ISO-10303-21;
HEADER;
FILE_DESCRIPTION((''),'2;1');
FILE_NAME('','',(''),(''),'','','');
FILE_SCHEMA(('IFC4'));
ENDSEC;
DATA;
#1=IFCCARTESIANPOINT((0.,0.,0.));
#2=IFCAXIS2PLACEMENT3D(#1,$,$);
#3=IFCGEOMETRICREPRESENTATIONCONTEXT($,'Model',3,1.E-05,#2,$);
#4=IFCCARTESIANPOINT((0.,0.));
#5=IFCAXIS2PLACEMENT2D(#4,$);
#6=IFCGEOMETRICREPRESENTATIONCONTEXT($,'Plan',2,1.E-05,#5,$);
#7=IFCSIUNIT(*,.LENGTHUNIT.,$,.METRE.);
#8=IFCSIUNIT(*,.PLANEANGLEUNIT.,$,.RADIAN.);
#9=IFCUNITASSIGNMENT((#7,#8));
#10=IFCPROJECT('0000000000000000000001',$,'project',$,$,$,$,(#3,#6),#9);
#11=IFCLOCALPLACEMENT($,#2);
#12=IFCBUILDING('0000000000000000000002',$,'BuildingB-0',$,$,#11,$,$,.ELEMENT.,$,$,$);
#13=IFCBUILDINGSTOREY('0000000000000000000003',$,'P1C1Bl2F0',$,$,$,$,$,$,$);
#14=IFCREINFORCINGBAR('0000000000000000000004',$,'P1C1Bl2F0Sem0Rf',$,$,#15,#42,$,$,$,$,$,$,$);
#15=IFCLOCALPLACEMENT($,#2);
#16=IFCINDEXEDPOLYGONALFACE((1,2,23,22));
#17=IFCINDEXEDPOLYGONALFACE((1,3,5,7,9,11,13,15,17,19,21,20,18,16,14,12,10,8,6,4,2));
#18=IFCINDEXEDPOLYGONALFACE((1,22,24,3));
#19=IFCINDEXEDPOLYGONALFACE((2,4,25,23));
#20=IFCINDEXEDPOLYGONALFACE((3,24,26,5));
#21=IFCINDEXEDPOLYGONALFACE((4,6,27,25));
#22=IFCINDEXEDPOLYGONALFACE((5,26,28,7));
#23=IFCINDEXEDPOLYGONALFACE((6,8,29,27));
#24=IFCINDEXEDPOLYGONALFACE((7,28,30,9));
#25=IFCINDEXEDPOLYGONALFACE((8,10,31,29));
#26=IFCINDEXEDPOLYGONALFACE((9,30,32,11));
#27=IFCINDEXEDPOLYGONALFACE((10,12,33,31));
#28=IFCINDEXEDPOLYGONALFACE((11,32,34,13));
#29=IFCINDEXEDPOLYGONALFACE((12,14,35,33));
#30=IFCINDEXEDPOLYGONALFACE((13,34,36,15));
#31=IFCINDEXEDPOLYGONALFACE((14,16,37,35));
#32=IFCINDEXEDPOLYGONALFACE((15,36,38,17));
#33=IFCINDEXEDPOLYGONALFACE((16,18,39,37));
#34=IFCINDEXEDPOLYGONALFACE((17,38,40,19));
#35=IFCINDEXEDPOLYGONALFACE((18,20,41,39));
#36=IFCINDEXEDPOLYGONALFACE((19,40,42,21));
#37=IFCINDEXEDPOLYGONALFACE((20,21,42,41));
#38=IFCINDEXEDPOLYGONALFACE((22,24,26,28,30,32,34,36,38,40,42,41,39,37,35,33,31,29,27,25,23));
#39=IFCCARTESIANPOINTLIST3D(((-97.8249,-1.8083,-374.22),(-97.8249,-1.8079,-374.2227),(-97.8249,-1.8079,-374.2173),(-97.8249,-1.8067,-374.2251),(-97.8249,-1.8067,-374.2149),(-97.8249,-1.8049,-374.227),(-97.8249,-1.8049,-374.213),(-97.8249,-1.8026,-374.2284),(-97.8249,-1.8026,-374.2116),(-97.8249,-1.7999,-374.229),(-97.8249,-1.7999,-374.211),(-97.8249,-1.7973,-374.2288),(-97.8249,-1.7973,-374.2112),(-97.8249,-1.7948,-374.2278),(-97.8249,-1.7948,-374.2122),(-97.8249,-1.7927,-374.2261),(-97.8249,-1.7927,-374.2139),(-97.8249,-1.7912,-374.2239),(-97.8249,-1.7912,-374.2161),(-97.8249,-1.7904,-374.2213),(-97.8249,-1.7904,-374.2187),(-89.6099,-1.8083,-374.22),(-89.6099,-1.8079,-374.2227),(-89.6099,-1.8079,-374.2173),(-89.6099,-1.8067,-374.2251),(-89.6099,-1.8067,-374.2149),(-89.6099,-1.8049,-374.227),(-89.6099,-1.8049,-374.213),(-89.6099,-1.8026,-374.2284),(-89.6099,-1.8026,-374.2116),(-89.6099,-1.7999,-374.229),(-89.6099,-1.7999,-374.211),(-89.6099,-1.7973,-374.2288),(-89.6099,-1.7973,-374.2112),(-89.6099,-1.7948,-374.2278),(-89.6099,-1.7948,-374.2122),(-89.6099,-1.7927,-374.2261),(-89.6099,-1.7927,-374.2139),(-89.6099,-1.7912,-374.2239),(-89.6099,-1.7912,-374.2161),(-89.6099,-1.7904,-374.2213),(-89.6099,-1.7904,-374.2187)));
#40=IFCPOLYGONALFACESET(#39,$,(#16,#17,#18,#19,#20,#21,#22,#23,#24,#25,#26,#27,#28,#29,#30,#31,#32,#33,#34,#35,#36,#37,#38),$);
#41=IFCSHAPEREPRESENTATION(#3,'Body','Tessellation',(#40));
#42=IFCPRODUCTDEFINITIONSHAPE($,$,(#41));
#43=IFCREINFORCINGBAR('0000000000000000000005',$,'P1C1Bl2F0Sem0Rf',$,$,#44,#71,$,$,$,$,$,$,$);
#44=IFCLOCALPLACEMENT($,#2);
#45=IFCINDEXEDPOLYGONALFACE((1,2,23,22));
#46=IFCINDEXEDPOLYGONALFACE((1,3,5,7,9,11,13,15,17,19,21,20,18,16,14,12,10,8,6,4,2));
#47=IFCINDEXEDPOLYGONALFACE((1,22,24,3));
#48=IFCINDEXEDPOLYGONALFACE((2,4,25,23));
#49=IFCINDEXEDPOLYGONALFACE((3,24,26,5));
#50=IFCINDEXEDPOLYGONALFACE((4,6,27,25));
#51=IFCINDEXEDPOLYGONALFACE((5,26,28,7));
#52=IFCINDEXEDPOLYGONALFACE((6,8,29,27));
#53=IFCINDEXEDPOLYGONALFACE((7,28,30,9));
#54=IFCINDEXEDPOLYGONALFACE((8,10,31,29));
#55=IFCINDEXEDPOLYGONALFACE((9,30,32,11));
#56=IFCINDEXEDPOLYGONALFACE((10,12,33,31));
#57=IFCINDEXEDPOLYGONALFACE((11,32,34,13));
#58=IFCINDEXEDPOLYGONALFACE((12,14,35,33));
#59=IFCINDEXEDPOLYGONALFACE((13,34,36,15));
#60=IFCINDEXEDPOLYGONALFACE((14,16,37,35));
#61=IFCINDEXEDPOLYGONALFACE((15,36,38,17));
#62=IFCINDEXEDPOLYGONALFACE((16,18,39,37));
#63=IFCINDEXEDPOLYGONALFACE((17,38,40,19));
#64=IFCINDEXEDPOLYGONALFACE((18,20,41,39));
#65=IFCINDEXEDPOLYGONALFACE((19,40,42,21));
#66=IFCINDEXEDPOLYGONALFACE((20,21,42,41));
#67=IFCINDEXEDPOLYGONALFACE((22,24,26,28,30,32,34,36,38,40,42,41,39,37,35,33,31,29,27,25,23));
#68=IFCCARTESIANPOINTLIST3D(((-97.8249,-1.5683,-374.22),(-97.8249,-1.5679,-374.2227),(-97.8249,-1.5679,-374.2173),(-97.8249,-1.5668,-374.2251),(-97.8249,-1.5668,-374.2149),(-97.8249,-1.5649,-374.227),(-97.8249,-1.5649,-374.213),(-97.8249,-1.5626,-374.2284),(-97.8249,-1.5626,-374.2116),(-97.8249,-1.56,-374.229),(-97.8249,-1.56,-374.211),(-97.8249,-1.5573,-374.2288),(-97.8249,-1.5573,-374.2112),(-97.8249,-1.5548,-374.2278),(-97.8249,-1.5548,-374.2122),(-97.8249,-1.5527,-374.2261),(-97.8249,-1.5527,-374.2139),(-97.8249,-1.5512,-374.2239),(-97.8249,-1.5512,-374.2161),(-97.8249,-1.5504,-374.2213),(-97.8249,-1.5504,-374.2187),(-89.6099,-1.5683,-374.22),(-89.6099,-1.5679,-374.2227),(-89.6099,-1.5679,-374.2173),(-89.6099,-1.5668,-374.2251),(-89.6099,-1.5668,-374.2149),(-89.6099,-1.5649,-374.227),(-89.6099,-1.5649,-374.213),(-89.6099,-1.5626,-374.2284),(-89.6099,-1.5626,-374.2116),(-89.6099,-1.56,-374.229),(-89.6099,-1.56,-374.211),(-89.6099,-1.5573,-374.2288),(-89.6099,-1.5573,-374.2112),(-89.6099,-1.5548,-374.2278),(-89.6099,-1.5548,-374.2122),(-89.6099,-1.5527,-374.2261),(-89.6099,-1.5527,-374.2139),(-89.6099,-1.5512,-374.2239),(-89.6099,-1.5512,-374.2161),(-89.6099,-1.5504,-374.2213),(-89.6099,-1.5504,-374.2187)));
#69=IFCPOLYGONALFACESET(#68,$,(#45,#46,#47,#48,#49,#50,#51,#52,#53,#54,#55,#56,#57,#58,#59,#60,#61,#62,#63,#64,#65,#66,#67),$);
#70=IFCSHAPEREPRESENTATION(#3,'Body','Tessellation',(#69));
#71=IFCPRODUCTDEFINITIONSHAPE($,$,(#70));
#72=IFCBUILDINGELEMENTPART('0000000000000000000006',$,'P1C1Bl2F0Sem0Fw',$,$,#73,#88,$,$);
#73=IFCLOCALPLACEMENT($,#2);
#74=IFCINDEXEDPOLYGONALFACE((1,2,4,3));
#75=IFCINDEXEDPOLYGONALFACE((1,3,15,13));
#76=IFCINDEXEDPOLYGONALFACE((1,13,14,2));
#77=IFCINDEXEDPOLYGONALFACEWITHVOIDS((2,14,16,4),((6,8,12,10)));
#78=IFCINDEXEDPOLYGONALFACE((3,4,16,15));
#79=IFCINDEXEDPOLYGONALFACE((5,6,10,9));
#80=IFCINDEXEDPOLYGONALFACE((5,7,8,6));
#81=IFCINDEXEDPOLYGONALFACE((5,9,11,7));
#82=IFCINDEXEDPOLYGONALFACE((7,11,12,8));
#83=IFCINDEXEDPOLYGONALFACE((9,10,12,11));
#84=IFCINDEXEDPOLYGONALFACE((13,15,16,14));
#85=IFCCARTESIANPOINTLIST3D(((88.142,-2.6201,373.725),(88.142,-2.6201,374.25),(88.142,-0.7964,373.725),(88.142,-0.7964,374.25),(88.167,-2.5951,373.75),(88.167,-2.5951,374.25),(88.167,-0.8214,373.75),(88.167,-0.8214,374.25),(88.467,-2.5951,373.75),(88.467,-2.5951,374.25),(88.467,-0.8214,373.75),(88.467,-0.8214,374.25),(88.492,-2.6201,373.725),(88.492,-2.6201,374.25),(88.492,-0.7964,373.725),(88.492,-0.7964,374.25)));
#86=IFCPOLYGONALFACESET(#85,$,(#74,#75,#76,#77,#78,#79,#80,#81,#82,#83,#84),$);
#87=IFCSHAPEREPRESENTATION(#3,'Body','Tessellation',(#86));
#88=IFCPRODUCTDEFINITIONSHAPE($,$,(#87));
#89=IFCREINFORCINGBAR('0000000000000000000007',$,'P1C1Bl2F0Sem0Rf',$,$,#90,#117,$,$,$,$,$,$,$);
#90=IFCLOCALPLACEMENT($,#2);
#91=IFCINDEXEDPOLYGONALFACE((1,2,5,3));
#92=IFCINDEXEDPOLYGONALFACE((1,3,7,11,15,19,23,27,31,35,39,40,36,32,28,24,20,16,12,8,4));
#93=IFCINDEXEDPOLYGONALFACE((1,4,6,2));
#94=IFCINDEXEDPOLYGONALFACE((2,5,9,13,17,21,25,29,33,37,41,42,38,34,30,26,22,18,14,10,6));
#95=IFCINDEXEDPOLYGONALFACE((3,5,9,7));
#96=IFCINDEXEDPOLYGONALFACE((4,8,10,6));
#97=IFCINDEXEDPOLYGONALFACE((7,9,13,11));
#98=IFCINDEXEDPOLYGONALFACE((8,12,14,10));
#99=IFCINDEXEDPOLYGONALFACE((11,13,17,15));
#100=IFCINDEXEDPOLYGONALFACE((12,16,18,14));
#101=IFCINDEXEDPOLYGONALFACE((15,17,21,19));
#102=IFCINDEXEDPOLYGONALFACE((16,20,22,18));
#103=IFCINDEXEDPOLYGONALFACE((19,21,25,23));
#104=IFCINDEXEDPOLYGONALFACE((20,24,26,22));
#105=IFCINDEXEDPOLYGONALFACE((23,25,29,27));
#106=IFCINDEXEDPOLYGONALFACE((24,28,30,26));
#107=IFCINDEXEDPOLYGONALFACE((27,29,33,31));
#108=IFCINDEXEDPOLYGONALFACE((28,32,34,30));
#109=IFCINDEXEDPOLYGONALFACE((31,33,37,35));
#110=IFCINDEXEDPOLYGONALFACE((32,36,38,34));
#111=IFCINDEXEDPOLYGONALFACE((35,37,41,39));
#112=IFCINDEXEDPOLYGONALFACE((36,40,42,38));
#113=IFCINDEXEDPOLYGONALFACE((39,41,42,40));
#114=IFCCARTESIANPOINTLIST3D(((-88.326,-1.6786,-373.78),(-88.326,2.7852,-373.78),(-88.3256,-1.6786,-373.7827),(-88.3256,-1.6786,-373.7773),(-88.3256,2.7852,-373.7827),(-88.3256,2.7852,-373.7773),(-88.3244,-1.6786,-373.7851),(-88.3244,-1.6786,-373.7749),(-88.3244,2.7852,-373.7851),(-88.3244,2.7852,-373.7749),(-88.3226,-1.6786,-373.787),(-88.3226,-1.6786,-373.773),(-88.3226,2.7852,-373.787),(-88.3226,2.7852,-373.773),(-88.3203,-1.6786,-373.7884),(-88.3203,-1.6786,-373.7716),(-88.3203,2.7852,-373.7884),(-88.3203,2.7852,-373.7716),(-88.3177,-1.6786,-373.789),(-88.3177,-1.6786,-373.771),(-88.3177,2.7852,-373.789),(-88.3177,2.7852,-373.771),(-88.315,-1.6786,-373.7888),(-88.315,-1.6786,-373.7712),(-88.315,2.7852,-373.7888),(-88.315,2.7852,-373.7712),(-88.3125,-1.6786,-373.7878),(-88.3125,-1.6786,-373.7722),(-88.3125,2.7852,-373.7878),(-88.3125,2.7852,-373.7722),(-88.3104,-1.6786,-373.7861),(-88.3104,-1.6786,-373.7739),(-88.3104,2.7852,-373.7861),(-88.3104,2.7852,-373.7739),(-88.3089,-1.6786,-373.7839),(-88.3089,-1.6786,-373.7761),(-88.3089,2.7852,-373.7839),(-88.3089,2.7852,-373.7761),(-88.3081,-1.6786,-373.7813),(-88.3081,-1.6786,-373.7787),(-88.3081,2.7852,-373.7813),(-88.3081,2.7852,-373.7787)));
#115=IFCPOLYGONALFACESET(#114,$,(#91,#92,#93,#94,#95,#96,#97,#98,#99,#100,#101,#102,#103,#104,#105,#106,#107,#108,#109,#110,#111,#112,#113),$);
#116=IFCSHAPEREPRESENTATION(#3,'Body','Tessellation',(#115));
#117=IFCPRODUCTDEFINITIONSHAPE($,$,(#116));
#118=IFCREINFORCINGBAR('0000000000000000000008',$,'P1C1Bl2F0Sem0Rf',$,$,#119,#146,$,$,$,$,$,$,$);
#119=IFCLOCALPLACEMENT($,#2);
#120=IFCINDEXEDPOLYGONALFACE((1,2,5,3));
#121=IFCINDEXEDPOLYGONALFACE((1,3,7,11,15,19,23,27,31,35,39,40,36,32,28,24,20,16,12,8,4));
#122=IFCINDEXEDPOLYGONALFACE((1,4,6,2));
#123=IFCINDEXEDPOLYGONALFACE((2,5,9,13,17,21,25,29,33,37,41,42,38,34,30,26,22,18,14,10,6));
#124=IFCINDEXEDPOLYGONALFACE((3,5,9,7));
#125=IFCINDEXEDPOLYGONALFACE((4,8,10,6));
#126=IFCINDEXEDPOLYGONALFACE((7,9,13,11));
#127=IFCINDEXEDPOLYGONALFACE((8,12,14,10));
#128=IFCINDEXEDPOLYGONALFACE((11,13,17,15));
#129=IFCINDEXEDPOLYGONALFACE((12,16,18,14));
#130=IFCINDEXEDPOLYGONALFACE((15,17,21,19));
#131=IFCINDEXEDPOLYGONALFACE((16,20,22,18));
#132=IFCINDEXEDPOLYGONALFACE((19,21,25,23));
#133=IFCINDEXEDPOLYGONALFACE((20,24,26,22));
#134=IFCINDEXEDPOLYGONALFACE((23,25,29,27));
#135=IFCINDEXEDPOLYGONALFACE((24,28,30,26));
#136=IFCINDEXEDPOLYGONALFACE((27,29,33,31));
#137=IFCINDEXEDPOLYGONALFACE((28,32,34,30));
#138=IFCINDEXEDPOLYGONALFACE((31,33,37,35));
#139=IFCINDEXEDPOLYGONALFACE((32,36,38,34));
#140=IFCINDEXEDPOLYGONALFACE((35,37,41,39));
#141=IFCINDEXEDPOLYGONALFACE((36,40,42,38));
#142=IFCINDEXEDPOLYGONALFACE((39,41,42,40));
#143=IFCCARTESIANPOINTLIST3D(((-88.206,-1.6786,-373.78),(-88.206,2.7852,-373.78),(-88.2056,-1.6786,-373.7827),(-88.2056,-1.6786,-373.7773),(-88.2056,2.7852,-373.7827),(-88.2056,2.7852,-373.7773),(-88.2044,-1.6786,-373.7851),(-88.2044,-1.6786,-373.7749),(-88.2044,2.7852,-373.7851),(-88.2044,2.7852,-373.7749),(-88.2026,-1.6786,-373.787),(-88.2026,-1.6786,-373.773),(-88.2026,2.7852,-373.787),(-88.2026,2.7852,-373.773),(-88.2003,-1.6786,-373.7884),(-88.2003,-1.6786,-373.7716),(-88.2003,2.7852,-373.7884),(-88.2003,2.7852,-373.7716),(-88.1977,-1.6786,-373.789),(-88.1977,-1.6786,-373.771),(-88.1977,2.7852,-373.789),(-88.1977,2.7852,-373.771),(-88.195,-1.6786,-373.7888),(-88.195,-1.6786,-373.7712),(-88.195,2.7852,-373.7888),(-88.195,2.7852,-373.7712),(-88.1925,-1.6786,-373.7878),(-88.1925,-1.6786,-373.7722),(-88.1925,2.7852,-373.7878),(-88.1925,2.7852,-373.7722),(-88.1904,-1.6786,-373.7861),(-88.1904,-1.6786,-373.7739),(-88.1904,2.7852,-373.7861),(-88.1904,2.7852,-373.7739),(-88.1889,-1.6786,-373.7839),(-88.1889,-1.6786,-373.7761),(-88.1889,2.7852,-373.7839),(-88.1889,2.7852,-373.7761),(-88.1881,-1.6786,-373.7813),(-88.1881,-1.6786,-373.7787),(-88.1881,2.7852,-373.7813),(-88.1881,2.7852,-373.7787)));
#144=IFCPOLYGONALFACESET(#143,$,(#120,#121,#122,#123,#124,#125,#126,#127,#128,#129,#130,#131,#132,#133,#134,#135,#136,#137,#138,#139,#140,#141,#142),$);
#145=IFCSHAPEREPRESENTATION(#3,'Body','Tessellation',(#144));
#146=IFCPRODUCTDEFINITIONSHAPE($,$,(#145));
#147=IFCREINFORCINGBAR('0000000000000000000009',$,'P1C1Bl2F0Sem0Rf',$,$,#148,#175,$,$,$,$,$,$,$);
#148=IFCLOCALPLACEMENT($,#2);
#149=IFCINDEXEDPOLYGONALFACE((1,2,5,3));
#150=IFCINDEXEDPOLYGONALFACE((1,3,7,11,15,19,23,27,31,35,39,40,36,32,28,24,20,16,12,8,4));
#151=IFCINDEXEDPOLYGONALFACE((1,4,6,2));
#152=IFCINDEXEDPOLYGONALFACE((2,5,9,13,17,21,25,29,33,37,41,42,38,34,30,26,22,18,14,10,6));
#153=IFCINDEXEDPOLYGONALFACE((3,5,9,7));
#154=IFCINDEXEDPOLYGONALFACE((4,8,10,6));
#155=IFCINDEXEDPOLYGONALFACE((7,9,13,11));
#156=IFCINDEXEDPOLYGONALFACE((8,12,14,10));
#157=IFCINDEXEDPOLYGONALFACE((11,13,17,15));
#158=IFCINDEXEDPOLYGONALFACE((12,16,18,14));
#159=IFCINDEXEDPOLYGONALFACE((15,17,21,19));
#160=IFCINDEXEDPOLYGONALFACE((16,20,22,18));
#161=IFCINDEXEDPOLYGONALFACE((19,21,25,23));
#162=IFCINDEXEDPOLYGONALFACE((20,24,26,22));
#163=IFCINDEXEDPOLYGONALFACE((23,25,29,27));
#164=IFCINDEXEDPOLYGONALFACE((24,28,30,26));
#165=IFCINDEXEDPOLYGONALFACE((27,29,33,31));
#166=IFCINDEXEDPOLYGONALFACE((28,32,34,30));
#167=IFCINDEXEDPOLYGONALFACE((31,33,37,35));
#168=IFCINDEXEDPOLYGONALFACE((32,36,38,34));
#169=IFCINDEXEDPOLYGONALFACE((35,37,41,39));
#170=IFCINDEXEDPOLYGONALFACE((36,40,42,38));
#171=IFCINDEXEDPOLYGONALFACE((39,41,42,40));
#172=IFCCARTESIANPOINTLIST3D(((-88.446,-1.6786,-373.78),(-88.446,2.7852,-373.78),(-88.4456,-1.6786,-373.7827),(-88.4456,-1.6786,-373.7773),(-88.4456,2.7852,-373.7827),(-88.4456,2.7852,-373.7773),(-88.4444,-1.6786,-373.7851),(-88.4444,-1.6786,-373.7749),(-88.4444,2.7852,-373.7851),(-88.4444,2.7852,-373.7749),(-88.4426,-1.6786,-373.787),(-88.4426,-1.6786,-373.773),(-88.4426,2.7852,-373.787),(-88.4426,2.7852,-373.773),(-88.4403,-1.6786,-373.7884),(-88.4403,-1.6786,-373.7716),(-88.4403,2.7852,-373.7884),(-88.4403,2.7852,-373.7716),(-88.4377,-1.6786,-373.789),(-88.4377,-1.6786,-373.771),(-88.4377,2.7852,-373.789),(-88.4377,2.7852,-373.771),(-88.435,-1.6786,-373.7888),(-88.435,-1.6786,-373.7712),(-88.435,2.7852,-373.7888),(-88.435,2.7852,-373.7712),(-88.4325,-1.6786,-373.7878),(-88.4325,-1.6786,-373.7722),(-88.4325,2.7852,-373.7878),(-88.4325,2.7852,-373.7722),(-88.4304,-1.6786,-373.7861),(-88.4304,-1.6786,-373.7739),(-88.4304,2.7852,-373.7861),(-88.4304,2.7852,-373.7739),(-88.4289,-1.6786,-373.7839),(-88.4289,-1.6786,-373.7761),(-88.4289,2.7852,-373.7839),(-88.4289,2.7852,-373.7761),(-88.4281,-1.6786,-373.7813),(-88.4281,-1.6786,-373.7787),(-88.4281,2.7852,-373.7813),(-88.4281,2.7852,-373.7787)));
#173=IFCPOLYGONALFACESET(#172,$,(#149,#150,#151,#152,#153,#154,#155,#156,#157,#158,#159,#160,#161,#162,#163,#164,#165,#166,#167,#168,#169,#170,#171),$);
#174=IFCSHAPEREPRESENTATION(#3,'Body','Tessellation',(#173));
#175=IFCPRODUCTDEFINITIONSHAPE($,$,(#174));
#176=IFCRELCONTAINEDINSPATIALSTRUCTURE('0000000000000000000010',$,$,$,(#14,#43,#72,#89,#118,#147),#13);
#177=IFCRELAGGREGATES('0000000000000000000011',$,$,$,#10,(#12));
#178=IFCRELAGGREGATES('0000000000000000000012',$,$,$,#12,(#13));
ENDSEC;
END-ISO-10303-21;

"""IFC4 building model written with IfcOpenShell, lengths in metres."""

from ifc_helpers import new_model, entity, si_unit, origin, origin_2d, place, context, project, spatial, polyline, outline, extrude, element, save


model = new_model("IFC4")

# Units and contexts
model_context = context("Model", 3, precision=1e-05, world=origin())
plan_context = context("Plan", 2, precision=1e-05, world=origin_2d())
ifc_project = project(units=[si_unit("LENGTHUNIT", "METRE"), si_unit("PLANEANGLEUNIT", "RADIAN")], contexts=[model_context, plan_context])

# Building, storey
building_placement = place(None, origin())
building = spatial("IfcBuilding", under=ifc_project, at=building_placement, Name="BuildingB-0", CompositionType="ELEMENT")
storey = spatial("IfcBuildingStorey", under=building, Name="P1C1Bl2F0")

# Reinforcing bars
element("IfcReinforcingBar", 1, inside=storey, Name="P1C1Bl2F0Sem0Rf", context=model_context, shape_type="SweptSolid", body=[
    entity("IfcSurfaceCurveSweptAreaSolid", entity("IfcCircleProfileDef", "AREA", None, None, 0.009), None, entity("IfcPolyline", [entity("IfcCartesianPoint", [97.8249, 1.7993, 374.22]), entity("IfcCartesianPoint", [89.6099, 1.7993, 374.22])]), None, None, entity("IfcPlane", entity("IfcAxis2Placement3D", entity("IfcCartesianPoint", [97.8249, 1.7993, 374.22]), entity("IfcDirection", [0.0, 0.0, 1.0]), entity("IfcDirection", [1.0, 0.0, 0.0])))),
])
element("IfcReinforcingBar", 2, inside=storey, Name="P1C1Bl2F0Sem0Rf", context=model_context, shape_type="SweptSolid", body=[
    entity("IfcSurfaceCurveSweptAreaSolid", entity("IfcCircleProfileDef", "AREA", None, None, 0.009), None, entity("IfcPolyline", [entity("IfcCartesianPoint", [97.8249, 1.5593, 374.22]), entity("IfcCartesianPoint", [89.6099, 1.5593, 374.22])]), None, None, entity("IfcPlane", entity("IfcAxis2Placement3D", entity("IfcCartesianPoint", [97.8249, 1.5593, 374.22]), entity("IfcDirection", [0.0, 0.0, 1.0]), entity("IfcDirection", [1.0, 0.0, 0.0])))),
])

# Building element part, opening
building_element_part_1 = element("IfcBuildingElementPart", 3, inside=storey, Name="P1C1Bl2F0Sem0Fw", context=model_context, shape_type="SweptSolid", body=[
    extrude(outline(polyline([(88.492, -2.6201, 373.725), (88.492, -0.7964, 373.725), (88.142, -0.7964, 373.725), (88.142, -2.6201, 373.725), (88.492, -2.6201, 373.725)])), None, (0.0, 0.0, 1.0), 0.525),
])
element("IfcOpeningElement", 4, inside=storey, cuts=building_element_part_1, context=model_context, shape_type="SweptSolid", body=[
    extrude(outline(polyline([(88.467, -2.5951, 373.75), (88.467, -0.8214, 373.75), (88.167, -0.8214, 373.75), (88.167, -2.5951, 373.75), (88.467, -2.5951, 373.75)])), None, (0.0, 0.0, 1.0), 0.5),
])

# Reinforcing bars
element("IfcReinforcingBar", 5, inside=storey, Name="P1C1Bl2F0Sem0Rf", context=model_context, shape_type="SweptSolid", body=[
    entity("IfcSurfaceCurveSweptAreaSolid", entity("IfcCircleProfileDef", "AREA", None, None, 0.009), None, entity("IfcPolyline", [entity("IfcCartesianPoint", [88.317, 1.6786, 373.78]), entity("IfcCartesianPoint", [88.317, -2.7852, 373.78])]), None, None, entity("IfcPlane", entity("IfcAxis2Placement3D", entity("IfcCartesianPoint", [88.317, 1.6786, 373.78]), entity("IfcDirection", [0.0, 0.0, 1.0]), entity("IfcDirection", [1.0, 0.0, 0.0])))),
])
element("IfcReinforcingBar", 6, inside=storey, Name="P1C1Bl2F0Sem0Rf", context=model_context, shape_type="SweptSolid", body=[
    entity("IfcSurfaceCurveSweptAreaSolid", entity("IfcCircleProfileDef", "AREA", None, None, 0.009), None, entity("IfcPolyline", [entity("IfcCartesianPoint", [88.197, 1.6786, 373.78]), entity("IfcCartesianPoint", [88.197, -2.7852, 373.78])]), None, None, entity("IfcPlane", entity("IfcAxis2Placement3D", entity("IfcCartesianPoint", [88.197, 1.6786, 373.78]), entity("IfcDirection", [0.0, 0.0, 1.0]), entity("IfcDirection", [1.0, 0.0, 0.0])))),
])
element("IfcReinforcingBar", 7, inside=storey, Name="P1C1Bl2F0Sem0Rf", context=model_context, shape_type="SweptSolid", body=[
    entity("IfcSurfaceCurveSweptAreaSolid", entity("IfcCircleProfileDef", "AREA", None, None, 0.009), None, entity("IfcPolyline", [entity("IfcCartesianPoint", [88.437, 1.6786, 373.78]), entity("IfcCartesianPoint", [88.437, -2.7852, 373.78])]), None, None, entity("IfcPlane", entity("IfcAxis2Placement3D", entity("IfcCartesianPoint", [88.437, 1.6786, 373.78]), entity("IfcDirection", [0.0, 0.0, 1.0]), entity("IfcDirection", [1.0, 0.0, 0.0])))),
])

save(model, "model.ifc")
